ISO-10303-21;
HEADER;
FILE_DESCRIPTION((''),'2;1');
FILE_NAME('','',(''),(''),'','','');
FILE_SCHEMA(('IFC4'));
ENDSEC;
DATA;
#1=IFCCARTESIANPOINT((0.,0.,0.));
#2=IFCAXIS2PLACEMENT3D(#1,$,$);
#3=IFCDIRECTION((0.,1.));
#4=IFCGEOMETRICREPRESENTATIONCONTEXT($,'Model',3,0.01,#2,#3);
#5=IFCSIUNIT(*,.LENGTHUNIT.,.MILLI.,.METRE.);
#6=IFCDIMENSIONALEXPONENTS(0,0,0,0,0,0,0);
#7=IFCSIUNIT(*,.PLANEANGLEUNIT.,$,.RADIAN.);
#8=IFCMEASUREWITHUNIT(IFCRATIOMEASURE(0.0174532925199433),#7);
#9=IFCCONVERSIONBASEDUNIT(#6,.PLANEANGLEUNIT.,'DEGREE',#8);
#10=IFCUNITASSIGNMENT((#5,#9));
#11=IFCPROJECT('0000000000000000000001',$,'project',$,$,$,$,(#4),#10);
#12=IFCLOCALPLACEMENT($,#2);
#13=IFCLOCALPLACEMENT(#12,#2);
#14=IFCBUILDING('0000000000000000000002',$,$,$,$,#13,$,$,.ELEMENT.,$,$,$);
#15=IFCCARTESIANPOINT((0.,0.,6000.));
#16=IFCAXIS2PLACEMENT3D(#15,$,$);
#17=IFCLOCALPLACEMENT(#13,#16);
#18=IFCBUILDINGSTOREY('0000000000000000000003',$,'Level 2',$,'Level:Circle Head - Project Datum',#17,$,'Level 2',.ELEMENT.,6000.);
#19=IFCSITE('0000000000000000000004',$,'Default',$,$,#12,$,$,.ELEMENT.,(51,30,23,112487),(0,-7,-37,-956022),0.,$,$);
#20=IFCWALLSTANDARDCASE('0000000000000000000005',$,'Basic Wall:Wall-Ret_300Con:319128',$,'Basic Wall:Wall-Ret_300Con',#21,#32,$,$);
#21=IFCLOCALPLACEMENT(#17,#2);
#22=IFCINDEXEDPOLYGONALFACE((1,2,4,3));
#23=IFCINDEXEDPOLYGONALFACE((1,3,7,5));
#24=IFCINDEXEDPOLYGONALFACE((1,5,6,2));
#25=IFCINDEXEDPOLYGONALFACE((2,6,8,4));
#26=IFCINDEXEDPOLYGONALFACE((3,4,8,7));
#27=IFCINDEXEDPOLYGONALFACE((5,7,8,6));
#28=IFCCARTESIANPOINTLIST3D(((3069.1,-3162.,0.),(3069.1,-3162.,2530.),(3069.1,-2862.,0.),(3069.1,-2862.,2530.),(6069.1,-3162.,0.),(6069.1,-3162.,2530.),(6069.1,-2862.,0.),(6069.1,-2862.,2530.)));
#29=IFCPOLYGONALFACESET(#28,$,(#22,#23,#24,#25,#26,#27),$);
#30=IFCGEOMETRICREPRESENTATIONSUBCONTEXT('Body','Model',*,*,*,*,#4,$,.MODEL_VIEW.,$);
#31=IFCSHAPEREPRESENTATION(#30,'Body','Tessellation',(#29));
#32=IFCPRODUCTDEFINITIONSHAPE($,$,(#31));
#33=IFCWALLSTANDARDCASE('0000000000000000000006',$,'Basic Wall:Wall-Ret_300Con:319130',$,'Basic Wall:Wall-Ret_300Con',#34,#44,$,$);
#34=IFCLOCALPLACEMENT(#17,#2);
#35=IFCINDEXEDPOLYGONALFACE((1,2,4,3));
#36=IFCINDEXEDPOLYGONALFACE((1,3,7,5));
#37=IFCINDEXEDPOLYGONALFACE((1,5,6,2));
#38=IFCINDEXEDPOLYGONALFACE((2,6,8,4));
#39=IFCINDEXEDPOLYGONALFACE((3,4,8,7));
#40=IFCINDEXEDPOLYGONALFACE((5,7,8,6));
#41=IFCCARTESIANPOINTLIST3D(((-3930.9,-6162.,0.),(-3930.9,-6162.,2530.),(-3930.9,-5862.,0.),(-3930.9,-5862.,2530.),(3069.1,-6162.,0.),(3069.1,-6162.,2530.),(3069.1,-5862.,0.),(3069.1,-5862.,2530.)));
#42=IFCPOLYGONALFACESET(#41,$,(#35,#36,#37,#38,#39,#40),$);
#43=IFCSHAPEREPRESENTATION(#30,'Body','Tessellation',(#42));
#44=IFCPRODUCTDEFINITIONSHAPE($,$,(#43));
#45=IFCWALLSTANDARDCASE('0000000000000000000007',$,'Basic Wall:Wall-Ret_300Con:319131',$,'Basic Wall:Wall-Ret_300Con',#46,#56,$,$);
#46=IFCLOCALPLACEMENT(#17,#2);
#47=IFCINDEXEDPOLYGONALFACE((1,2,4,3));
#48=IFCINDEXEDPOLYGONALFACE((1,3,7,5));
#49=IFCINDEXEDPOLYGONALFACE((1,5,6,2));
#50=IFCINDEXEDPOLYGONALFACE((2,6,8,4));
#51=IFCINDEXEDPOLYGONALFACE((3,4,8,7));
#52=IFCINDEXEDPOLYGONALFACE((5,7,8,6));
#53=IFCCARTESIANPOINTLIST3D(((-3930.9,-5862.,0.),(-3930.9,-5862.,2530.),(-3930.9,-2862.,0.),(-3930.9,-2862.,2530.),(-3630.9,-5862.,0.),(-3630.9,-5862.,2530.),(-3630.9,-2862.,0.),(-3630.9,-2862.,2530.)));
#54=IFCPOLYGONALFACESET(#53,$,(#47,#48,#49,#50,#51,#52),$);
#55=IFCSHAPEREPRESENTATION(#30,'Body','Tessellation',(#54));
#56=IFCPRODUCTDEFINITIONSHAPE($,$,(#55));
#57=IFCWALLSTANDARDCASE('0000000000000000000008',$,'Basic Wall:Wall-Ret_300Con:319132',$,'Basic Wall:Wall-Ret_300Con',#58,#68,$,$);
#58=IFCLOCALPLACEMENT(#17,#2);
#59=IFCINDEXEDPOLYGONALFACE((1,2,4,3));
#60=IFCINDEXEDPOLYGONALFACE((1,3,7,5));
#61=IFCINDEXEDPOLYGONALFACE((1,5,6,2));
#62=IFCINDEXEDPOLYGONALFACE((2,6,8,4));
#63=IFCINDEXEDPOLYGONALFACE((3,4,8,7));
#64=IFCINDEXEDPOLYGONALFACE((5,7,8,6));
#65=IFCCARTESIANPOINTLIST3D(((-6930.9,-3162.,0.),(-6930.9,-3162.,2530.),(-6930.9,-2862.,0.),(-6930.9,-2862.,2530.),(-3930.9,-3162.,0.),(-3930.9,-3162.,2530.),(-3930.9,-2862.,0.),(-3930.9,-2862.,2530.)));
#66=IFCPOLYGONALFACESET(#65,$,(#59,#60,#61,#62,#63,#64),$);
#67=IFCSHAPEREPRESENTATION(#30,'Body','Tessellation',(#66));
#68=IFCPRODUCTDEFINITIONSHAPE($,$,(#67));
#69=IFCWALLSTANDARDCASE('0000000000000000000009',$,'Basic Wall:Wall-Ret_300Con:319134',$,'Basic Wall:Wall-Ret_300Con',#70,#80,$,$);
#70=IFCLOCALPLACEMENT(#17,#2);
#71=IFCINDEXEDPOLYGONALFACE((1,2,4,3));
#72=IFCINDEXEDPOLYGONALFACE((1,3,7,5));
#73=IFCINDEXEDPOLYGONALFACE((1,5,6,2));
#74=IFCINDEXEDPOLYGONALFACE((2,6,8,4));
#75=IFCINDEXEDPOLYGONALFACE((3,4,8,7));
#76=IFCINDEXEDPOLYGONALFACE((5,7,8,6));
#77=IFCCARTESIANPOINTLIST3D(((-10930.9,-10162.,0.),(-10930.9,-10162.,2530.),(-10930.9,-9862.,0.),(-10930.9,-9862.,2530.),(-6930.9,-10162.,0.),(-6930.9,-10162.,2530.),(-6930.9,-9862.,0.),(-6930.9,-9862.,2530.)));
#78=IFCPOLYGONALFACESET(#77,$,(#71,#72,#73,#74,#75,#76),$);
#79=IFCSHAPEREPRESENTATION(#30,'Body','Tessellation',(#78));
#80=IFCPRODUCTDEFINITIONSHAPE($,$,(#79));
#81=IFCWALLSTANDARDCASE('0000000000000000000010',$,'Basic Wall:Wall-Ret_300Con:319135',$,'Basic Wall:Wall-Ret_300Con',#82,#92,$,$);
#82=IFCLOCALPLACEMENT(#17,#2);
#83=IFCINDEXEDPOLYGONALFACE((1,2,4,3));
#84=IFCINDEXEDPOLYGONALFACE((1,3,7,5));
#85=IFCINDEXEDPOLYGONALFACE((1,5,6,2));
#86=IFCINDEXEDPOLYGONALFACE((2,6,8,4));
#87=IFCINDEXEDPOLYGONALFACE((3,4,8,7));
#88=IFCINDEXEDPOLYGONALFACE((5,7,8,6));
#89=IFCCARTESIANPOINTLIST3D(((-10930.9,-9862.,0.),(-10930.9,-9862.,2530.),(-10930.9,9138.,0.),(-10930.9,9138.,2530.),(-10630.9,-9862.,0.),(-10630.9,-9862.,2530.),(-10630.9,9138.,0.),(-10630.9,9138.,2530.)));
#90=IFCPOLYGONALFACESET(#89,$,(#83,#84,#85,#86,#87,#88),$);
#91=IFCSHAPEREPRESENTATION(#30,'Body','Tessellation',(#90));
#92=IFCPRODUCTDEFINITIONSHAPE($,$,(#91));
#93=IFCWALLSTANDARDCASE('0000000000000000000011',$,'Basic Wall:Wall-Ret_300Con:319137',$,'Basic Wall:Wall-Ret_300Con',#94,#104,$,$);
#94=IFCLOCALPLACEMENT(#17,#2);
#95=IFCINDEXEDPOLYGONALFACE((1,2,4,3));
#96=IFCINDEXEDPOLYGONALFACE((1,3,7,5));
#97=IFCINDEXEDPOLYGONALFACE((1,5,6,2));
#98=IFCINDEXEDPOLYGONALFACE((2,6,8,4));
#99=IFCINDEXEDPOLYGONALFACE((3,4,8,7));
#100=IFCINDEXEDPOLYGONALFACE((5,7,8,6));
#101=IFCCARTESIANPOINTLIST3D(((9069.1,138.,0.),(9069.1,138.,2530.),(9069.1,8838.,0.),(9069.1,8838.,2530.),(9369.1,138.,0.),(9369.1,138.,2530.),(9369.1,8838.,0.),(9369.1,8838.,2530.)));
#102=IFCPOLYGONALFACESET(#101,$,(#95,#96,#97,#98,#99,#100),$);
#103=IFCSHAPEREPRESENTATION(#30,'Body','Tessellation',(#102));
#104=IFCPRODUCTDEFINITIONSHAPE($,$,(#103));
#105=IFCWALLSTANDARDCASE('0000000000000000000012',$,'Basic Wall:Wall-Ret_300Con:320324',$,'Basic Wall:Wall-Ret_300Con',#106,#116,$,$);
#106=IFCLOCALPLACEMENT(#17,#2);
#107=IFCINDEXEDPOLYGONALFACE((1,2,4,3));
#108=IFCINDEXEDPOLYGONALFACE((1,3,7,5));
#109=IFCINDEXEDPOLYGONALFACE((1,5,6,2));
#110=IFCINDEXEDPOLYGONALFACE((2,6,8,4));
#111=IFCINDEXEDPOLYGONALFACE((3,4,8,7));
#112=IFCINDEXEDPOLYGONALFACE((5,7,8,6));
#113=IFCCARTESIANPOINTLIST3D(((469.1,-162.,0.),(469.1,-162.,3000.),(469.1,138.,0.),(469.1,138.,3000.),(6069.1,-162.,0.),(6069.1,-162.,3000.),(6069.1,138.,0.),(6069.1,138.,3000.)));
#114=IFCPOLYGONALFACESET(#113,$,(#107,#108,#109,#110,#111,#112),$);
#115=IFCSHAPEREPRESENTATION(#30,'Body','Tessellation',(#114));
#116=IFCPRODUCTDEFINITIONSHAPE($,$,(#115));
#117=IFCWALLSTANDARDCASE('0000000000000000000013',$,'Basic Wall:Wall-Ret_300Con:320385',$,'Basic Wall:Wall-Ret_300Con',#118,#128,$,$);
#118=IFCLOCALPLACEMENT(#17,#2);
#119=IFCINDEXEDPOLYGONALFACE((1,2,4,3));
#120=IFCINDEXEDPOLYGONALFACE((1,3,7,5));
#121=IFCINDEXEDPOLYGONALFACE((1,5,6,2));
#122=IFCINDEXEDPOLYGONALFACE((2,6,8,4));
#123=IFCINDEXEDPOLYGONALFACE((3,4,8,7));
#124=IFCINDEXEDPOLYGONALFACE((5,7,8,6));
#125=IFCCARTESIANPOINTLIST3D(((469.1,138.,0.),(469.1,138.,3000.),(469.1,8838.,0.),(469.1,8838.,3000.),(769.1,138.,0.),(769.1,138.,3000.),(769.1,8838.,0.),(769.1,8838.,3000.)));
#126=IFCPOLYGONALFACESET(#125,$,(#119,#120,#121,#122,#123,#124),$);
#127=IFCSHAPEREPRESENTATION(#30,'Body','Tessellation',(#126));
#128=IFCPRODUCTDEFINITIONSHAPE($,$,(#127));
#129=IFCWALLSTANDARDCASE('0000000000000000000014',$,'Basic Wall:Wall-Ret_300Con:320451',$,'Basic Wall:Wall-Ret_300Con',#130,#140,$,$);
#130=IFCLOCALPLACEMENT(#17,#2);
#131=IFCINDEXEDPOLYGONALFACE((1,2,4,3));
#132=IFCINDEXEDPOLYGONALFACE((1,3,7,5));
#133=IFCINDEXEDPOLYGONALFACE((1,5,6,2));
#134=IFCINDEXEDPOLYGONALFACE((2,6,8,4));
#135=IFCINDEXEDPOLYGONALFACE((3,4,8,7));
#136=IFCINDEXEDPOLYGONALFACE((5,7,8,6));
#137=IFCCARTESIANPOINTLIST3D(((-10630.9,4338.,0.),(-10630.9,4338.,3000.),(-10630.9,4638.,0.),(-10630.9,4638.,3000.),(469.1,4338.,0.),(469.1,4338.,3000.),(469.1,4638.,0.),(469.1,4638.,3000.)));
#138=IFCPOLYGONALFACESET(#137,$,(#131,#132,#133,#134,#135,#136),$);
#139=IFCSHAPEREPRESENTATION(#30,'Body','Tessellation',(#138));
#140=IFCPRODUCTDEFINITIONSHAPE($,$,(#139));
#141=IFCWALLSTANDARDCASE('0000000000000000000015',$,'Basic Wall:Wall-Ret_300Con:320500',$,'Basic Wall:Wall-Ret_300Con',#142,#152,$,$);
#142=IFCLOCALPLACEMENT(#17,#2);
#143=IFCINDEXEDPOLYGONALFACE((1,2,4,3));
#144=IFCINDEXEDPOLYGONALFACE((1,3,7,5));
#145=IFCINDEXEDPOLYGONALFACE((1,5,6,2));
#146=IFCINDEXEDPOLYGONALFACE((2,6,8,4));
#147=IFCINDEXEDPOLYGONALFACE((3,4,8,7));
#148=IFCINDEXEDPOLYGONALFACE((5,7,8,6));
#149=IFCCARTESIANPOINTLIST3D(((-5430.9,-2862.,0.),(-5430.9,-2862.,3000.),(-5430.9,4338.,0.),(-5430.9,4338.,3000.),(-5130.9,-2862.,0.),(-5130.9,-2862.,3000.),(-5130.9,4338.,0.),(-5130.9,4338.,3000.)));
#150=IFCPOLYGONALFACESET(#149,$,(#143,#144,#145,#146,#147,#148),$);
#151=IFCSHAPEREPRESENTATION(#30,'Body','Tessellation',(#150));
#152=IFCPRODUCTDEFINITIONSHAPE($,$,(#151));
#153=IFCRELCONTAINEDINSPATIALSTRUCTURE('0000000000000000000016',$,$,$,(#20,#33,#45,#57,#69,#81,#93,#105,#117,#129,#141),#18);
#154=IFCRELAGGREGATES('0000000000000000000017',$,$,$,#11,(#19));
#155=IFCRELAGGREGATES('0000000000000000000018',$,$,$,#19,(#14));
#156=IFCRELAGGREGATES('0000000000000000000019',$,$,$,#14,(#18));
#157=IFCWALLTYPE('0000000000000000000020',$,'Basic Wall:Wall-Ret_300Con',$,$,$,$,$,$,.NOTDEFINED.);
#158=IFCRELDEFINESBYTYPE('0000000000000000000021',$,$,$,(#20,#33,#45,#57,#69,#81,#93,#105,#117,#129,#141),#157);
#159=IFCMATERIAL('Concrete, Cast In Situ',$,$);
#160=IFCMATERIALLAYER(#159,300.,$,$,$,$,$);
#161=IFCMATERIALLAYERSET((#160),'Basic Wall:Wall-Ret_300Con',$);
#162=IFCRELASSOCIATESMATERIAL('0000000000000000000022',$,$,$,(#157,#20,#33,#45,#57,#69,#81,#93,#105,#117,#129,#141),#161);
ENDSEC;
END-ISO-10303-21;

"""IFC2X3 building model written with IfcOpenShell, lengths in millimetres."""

from ifc_helpers import new_model, entity, si_unit, converted_unit, direction, frame, frame_2d, origin, place, context, subcontext, project, spatial, polyline, rectangle, extrude, clip, bounded_halfspace, material, layer, layer_set, layer_usage, type_object, element, save


model = new_model("IFC2X3")

# Units and contexts
model_context = context("Model", 3, precision=0.01, world=origin(), true_north=direction((0.0, 1.0)))
body_context = subcontext(model_context, "Body", "Model", "MODEL_VIEW")
ifc_project = project(units=[si_unit("LENGTHUNIT", "METRE", prefix="MILLI"), converted_unit("PLANEANGLEUNIT", "DEGREE", entity("IfcRatioMeasure", 0.0174532925199433), si_unit("PLANEANGLEUNIT", "RADIAN"), dimensions=[0, 0, 0, 0, 0, 0, 0])], contexts=[model_context])

# Site, building, storey
site_placement = place(None, origin())
site = spatial("IfcSite", under=ifc_project, at=site_placement, Name="Default", CompositionType="ELEMENT", RefLatitude=(51, 30, 23, 112487), RefLongitude=(0, -7, -37, -956022), RefElevation=0.0)
building_placement = place(site_placement, origin())
building = spatial("IfcBuilding", under=site, at=building_placement, CompositionType="ELEMENT")
storey_placement = place(building_placement, frame((0.0, 0.0, 6000.0)))
storey = spatial("IfcBuildingStorey", under=building, at=storey_placement, Name="Level 2", ObjectType="Level:Circle Head - Project Datum", LongName="Level 2", CompositionType="ELEMENT", Elevation=6000.0)

# Walls
ifc_material = material(Name="Concrete, Cast In Situ")
ifc_layer = layer(ifc_material, 300.0)
ifc_layer_set = layer_set([ifc_layer], Name="Basic Wall:Wall-Ret_300Con")
wall_type = type_object("IfcWallType", Name="Basic Wall:Wall-Ret_300Con", PredefinedType="NOTDEFINED", material=ifc_layer_set)
ifc_layer_usage_1 = layer_usage(ifc_layer_set, "AXIS2", "NEGATIVE", 150.0)
wall_1_placement = place(storey_placement, frame((6069.1, -3012.0, 0.0), z_axis=(0.0, 0.0, 1.0), x_axis=(-1.0, 0.0, 0.0)))
element("IfcWallStandardCase", 1, at=wall_1_placement, inside=storey, type_object=wall_type, material=ifc_layer_usage_1, Name="Basic Wall:Wall-Ret_300Con:319128", ObjectType="Basic Wall:Wall-Ret_300Con", context=body_context, shape_type="Clipping", body=[
    clip(extrude(rectangle(XDim=3000.0, YDim=300.0, at=frame_2d((1500.0, 0.0), x_axis=(-1.0, 0.0))), origin(), (0.0, 0.0, 1.0), 2530.0), bounded_halfspace(frame((0.0, -150.0, 2530.0), z_axis=(0.0, 0.0, -1.0), x_axis=(-1.0, 0.0, 0.0)), True, frame((0.0, -150.0, 2530.0)), polyline([(0.0, 0.0), (3000.0, 0.0), (3000.0, 300.0), (2700.0, 300.0), (0.0, 300.0), (0.0, 0.0)]))),
])
ifc_layer_usage_2 = layer_usage(ifc_layer_set, "AXIS2", "NEGATIVE", 150.0)
wall_2_placement = place(storey_placement, frame((3069.1, -6012.0, 0.0), z_axis=(0.0, 0.0, 1.0), x_axis=(-1.0, 0.0, 0.0)))
element("IfcWallStandardCase", 2, at=wall_2_placement, inside=storey, type_object=wall_type, material=ifc_layer_usage_2, Name="Basic Wall:Wall-Ret_300Con:319130", ObjectType="Basic Wall:Wall-Ret_300Con", context=body_context, shape_type="Clipping", body=[
    clip(extrude(rectangle(XDim=7000.0, YDim=300.0, at=frame_2d((3500.0, 0.0), x_axis=(-1.0, 0.0))), origin(), (0.0, 0.0, 1.0), 2530.0), bounded_halfspace(frame((0.0, -150.0, 2530.0), z_axis=(0.0, 0.0, -1.0), x_axis=(-1.0, 0.0, 0.0)), True, frame((0.0, -150.0, 2530.0)), polyline([(0.0, 0.0), (6700.0, 0.0), (7000.0, 0.0), (7000.0, 300.0), (0.0, 300.0), (0.0, 0.0)]))),
])
ifc_layer_usage_3 = layer_usage(ifc_layer_set, "AXIS2", "NEGATIVE", 150.0)
wall_3_placement = place(storey_placement, frame((-3780.9, -5862.0, 0.0), z_axis=(0.0, 0.0, 1.0), x_axis=(0.0, 1.0, 0.0)))
element("IfcWallStandardCase", 3, at=wall_3_placement, inside=storey, type_object=wall_type, material=ifc_layer_usage_3, Name="Basic Wall:Wall-Ret_300Con:319131", ObjectType="Basic Wall:Wall-Ret_300Con", context=body_context, shape_type="Clipping", body=[
    clip(extrude(rectangle(XDim=3000.0, YDim=300.0, at=frame_2d((1500.0, 0.0), x_axis=(-1.0, 0.0))), origin(), (0.0, 0.0, 1.0), 2530.0), bounded_halfspace(frame((0.0, -150.0, 2530.0), z_axis=(0.0, 0.0, -1.0), x_axis=(0.0, -1.0, 0.0)), True, frame((0.0, -150.0, 2530.0)), polyline([(0.0, 0.0), (3000.0, 0.0), (3000.0, 300.0), (2700.0, 300.0), (0.0, 300.0), (0.0, 0.0)]))),
])
ifc_layer_usage_4 = layer_usage(ifc_layer_set, "AXIS2", "NEGATIVE", 150.0)
wall_4_placement = place(storey_placement, frame((-3930.9, -3012.0, 0.0), z_axis=(0.0, 0.0, 1.0), x_axis=(-1.0, 0.0, 0.0)))
element("IfcWallStandardCase", 4, at=wall_4_placement, inside=storey, type_object=wall_type, material=ifc_layer_usage_4, Name="Basic Wall:Wall-Ret_300Con:319132", ObjectType="Basic Wall:Wall-Ret_300Con", context=body_context, shape_type="Clipping", body=[
    clip(extrude(rectangle(XDim=3000.0, YDim=300.0, at=frame_2d((1500.0, 0.0), x_axis=(-1.0, 0.0))), origin(), (0.0, 0.0, 1.0), 2530.0), bounded_halfspace(frame((0.0, -150.0, 2530.0), z_axis=(0.0, 0.0, -1.0), x_axis=(-1.0, 0.0, 0.0)), True, frame((0.0, -150.0, 2530.0)), polyline([(0.0, 0.0), (3000.0, 0.0), (3000.0, 300.0), (2700.0, 300.0), (0.0, 300.0), (0.0, 0.0)]))),
])
ifc_layer_usage_5 = layer_usage(ifc_layer_set, "AXIS2", "NEGATIVE", 150.0)
wall_5_placement = place(storey_placement, frame((-6930.9, -10012.0, 0.0), z_axis=(0.0, 0.0, 1.0), x_axis=(-1.0, 0.0, 0.0)))
element("IfcWallStandardCase", 5, at=wall_5_placement, inside=storey, type_object=wall_type, material=ifc_layer_usage_5, Name="Basic Wall:Wall-Ret_300Con:319134", ObjectType="Basic Wall:Wall-Ret_300Con", context=body_context, shape_type="Clipping", body=[
    clip(extrude(rectangle(XDim=4000.0, YDim=300.0, at=frame_2d((2000.0, 0.0), x_axis=(-1.0, 0.0))), origin(), (0.0, 0.0, 1.0), 2530.0), bounded_halfspace(frame((0.0, -150.0, 2530.0), z_axis=(0.0, 0.0, -1.0), x_axis=(-1.0, 0.0, 0.0)), True, frame((0.0, -150.0, 2530.0)), polyline([(0.0, 0.0), (3700.0, 0.0), (4000.0, 0.0), (4000.0, 300.0), (0.0, 300.0), (0.0, 0.0)]))),
])
ifc_layer_usage_6 = layer_usage(ifc_layer_set, "AXIS2", "NEGATIVE", 150.0)
wall_6_placement = place(storey_placement, frame((-10780.9, -9862.0, 0.0), z_axis=(0.0, 0.0, 1.0), x_axis=(0.0, 1.0, 0.0)))
element("IfcWallStandardCase", 6, at=wall_6_placement, inside=storey, type_object=wall_type, material=ifc_layer_usage_6, Name="Basic Wall:Wall-Ret_300Con:319135", ObjectType="Basic Wall:Wall-Ret_300Con", context=body_context, shape_type="Clipping", body=[
    clip(extrude(rectangle(XDim=19000.0, YDim=300.0, at=frame_2d((9500.0, 0.0), x_axis=(-1.0, 0.0))), origin(), (0.0, 0.0, 1.0), 2530.0), bounded_halfspace(frame((0.0, -150.0, 2530.0), z_axis=(0.0, 0.0, -1.0), x_axis=(0.0, -1.0, 0.0)), True, frame((0.0, -150.0, 2530.0)), polyline([(0.0, 0.0), (18700.0, 0.0), (18994.8, 0.0), (18994.8, 300.0), (0.0, 300.0), (0.0, 0.0)]))),
])
ifc_layer_usage_7 = layer_usage(ifc_layer_set, "AXIS2", "NEGATIVE", 150.0)
wall_7_placement = place(storey_placement, frame((9219.1, 8838.0, 0.0), z_axis=(0.0, 0.0, 1.0), x_axis=(0.0, -1.0, 0.0)))
element("IfcWallStandardCase", 7, at=wall_7_placement, inside=storey, type_object=wall_type, material=ifc_layer_usage_7, Name="Basic Wall:Wall-Ret_300Con:319137", ObjectType="Basic Wall:Wall-Ret_300Con", context=body_context, shape_type="Clipping", body=[
    clip(extrude(rectangle(XDim=8700.0, YDim=300.0, at=frame_2d((4350.0, 0.0), x_axis=(-1.0, 0.0))), origin(), (0.0, 0.0, 1.0), 2530.0), bounded_halfspace(frame((0.0, -150.0, 2530.0), z_axis=(0.0, 0.0, -1.0), x_axis=(0.0, 1.0, 0.0)), True, frame((0.0, -150.0, 2530.0)), polyline([(0.0, 0.0), (8700.0, 0.0), (8700.0, 280.1), (0.0, 280.1), (0.0, 0.0)]))),
])
ifc_layer_usage_8 = layer_usage(ifc_layer_set, "AXIS2", "NEGATIVE", 150.0)
wall_8_placement = place(storey_placement, frame((6069.1, -12.0, 0.0), z_axis=(0.0, 0.0, 1.0), x_axis=(-1.0, 0.0, 0.0)))
element("IfcWallStandardCase", 8, at=wall_8_placement, inside=storey, type_object=wall_type, material=ifc_layer_usage_8, Name="Basic Wall:Wall-Ret_300Con:320324", ObjectType="Basic Wall:Wall-Ret_300Con", context=body_context, shape_type="SweptSolid", body=[
    extrude(rectangle(XDim=5600.0, YDim=300.0, at=frame_2d((2800.0, 0.0), x_axis=(-1.0, 0.0))), origin(), (0.0, 0.0, 1.0), 3000.0),
])
ifc_layer_usage_9 = layer_usage(ifc_layer_set, "AXIS2", "NEGATIVE", 150.0)
wall_9_placement = place(storey_placement, frame((619.1, 138.0, 0.0), z_axis=(0.0, 0.0, 1.0), x_axis=(0.0, 1.0, 0.0)))
element("IfcWallStandardCase", 9, at=wall_9_placement, inside=storey, type_object=wall_type, material=ifc_layer_usage_9, Name="Basic Wall:Wall-Ret_300Con:320385", ObjectType="Basic Wall:Wall-Ret_300Con", context=body_context, shape_type="SweptSolid", body=[
    extrude(rectangle(XDim=8700.0, YDim=300.0, at=frame_2d((4350.0, 0.0), x_axis=(-1.0, 0.0))), origin(), (0.0, 0.0, 1.0), 3000.0),
])
ifc_layer_usage_10 = layer_usage(ifc_layer_set, "AXIS2", "NEGATIVE", 150.0)
wall_10_placement = place(storey_placement, frame((469.1, 4488.0, 0.0), z_axis=(0.0, 0.0, 1.0), x_axis=(-1.0, 0.0, 0.0)))
element("IfcWallStandardCase", 10, at=wall_10_placement, inside=storey, type_object=wall_type, material=ifc_layer_usage_10, Name="Basic Wall:Wall-Ret_300Con:320451", ObjectType="Basic Wall:Wall-Ret_300Con", context=body_context, shape_type="SweptSolid", body=[
    extrude(rectangle(XDim=11100.0, YDim=300.0, at=frame_2d((5550.0, 0.0), x_axis=(-1.0, 0.0))), origin(), (0.0, 0.0, 1.0), 3000.0),
])
ifc_layer_usage_11 = layer_usage(ifc_layer_set, "AXIS2", "NEGATIVE", 150.0)
wall_11_placement = place(storey_placement, frame((-5280.9, -2862.0, 0.0), z_axis=(0.0, 0.0, 1.0), x_axis=(0.0, 1.0, 0.0)))
element("IfcWallStandardCase", 11, at=wall_11_placement, inside=storey, type_object=wall_type, material=ifc_layer_usage_11, Name="Basic Wall:Wall-Ret_300Con:320500", ObjectType="Basic Wall:Wall-Ret_300Con", context=body_context, shape_type="SweptSolid", body=[
    extrude(rectangle(XDim=7200.0, YDim=300.0, at=frame_2d((3600.0, 0.0), x_axis=(-1.0, 0.0))), origin(), (0.0, 0.0, 1.0), 3000.0),
])

save(model, "model.ifc")
